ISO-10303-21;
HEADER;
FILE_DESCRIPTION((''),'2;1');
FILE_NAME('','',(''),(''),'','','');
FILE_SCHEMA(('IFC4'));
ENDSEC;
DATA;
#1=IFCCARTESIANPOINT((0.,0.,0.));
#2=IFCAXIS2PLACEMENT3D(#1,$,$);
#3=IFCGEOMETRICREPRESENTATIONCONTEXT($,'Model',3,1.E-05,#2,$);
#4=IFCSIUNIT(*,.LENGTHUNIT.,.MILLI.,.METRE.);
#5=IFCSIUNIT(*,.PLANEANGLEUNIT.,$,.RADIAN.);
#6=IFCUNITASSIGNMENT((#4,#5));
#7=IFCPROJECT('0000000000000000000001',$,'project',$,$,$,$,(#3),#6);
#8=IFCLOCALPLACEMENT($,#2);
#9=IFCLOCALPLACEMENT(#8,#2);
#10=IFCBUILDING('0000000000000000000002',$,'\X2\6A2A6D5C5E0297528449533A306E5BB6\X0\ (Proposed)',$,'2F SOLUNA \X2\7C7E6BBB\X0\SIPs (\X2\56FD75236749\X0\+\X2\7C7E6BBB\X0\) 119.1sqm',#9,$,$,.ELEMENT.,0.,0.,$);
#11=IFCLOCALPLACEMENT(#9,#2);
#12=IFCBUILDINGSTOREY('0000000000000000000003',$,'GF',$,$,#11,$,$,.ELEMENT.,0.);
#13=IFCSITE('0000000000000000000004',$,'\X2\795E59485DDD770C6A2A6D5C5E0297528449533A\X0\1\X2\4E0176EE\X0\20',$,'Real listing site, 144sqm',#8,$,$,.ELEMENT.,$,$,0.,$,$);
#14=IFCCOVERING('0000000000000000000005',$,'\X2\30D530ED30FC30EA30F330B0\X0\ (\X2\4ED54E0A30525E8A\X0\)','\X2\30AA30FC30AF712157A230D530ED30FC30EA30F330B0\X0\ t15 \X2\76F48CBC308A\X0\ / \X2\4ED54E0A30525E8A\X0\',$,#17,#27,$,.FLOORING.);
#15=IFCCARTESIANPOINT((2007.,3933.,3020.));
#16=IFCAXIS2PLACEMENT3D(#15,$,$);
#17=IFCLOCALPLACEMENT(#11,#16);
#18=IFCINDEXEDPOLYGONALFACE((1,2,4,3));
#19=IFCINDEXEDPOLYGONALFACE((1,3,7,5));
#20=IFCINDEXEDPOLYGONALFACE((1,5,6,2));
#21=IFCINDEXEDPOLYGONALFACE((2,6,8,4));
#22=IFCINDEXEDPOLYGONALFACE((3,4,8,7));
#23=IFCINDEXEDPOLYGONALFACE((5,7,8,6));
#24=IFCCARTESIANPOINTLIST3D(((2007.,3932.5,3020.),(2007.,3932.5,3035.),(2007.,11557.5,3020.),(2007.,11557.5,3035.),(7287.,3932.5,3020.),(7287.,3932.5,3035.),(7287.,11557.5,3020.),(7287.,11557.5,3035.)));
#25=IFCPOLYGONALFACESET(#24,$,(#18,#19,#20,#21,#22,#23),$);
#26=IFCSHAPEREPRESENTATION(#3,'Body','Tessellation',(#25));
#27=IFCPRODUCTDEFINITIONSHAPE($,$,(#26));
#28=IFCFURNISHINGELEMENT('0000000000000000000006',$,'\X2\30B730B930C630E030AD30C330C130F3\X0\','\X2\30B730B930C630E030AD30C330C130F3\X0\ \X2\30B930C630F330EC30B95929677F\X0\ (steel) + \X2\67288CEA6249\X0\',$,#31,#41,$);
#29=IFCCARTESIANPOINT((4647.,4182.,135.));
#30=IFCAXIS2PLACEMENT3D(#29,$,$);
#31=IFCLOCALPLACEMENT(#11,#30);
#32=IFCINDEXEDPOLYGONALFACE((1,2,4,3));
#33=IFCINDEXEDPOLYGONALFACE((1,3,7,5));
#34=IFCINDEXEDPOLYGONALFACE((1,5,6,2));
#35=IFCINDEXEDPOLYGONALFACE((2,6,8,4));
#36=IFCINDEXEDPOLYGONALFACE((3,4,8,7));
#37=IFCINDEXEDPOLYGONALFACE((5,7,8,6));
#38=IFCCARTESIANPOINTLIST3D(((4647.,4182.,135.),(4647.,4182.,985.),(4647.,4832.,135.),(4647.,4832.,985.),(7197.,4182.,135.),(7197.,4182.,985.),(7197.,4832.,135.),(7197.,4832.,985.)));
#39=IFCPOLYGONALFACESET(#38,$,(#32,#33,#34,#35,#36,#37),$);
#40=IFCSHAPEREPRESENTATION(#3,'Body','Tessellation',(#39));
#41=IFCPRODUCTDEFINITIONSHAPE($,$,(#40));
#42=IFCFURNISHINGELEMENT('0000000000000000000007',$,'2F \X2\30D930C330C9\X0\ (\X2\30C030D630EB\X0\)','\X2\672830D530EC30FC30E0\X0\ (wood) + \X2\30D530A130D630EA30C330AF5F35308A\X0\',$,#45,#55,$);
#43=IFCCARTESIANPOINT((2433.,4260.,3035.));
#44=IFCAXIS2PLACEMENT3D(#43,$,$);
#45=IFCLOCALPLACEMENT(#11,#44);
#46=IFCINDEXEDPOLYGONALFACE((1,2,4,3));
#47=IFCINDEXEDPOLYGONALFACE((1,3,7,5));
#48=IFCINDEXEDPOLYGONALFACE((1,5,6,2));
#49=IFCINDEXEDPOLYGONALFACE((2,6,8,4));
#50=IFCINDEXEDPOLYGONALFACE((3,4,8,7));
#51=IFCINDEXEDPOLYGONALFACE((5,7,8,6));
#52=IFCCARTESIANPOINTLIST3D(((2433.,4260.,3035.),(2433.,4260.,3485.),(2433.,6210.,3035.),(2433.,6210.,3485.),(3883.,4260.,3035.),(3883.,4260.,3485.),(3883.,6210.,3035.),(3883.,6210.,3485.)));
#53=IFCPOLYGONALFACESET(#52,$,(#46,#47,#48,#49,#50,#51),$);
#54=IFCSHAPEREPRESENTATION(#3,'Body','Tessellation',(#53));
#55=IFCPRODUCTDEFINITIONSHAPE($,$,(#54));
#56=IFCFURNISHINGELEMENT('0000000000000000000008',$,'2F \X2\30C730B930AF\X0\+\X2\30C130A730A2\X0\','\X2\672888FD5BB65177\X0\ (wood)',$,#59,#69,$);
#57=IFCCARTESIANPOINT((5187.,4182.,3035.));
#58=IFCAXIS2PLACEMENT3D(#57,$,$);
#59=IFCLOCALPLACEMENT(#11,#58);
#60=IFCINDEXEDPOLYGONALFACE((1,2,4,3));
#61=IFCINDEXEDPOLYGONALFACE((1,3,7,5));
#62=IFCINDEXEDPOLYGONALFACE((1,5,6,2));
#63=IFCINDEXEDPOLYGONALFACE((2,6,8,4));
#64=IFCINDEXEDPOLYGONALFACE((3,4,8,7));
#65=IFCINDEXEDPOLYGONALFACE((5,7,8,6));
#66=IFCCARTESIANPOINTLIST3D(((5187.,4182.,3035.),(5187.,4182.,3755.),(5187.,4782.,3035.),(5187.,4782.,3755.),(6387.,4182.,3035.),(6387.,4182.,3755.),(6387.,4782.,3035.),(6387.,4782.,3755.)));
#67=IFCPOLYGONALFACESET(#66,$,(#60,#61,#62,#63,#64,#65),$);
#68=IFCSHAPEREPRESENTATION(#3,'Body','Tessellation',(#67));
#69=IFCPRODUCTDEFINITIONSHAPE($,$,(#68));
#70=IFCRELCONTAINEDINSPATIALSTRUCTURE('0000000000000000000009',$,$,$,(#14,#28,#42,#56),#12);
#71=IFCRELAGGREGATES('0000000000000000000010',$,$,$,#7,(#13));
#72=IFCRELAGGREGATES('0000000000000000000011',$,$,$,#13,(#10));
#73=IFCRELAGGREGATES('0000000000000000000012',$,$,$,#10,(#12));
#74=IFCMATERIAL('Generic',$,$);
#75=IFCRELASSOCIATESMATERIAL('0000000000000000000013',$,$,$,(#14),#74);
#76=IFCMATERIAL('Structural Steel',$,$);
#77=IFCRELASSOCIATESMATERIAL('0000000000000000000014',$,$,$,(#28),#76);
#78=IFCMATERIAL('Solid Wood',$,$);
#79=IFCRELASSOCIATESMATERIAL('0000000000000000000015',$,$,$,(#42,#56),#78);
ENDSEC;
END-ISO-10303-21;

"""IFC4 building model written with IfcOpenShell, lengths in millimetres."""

from ifc_helpers import new_model, si_unit, frame, frame_2d, origin, place, context, project, spatial, rectangle, extrude, material, element, save


model = new_model("IFC4")

# Units and contexts
model_context = context("Model", 3, precision=1e-05, world=origin())
ifc_project = project(units=[si_unit("LENGTHUNIT", "METRE", prefix="MILLI"), si_unit("PLANEANGLEUNIT", "RADIAN")], contexts=[model_context])

# Site, building, storey
site_placement = place(None, origin())
site = spatial("IfcSite", under=ifc_project, at=site_placement, Name="神奈川県横浜市青葉区1丁目20", ObjectType="Real listing site, 144sqm", CompositionType="ELEMENT", RefElevation=0.0)
building_placement = place(site_placement, origin())
building = spatial("IfcBuilding", under=site, at=building_placement, Name="横浜市青葉区の家 (Proposed)", ObjectType="2F SOLUNA 籾殻SIPs (国産杉+籾殻) 119.1sqm", CompositionType="ELEMENT", ElevationOfRefHeight=0.0, ElevationOfTerrain=0.0)
storey_placement = place(building_placement, origin())
storey = spatial("IfcBuildingStorey", under=building, at=storey_placement, Name="GF", CompositionType="ELEMENT", Elevation=0.0)

# Shared definitions
ifc_material_1 = material(Name="Solid Wood")

# Shared definitions
ifc_material_2 = material(Name="Generic")

# Shared definitions
ifc_material_3 = material(Name="Structural Steel")

# Covering
covering_placement = place(storey_placement, frame((2007.0, 3933.0, 3020.0)))
element("IfcCovering", 1, at=covering_placement, inside=storey, material=ifc_material_2, Name="フローリング (仕上げ床)", Description="オーク無垢フローリング t15 直貼り / 仕上げ床", PredefinedType="FLOORING", context=model_context, shape_type="SweptSolid", body=[
    extrude(rectangle(XDim=5280.0, YDim=7625.0, at=frame_2d((2640.0, 3812.0))), frame((2007.0, 3933.0, 3020.0)), (0.0, 0.0, 1.0), 15.0),
])

# Furnishing elements
furnishing_1_placement = place(storey_placement, frame((4647.0, 4182.0, 135.0)))
element("IfcFurnishingElement", 2, at=furnishing_1_placement, inside=storey, material=ifc_material_3, Name="システムキッチン", Description="システムキッチン ステンレス天板 (steel) + 木質扉", context=model_context, shape_type="SweptSolid", body=[
    extrude(rectangle(XDim=2550.0, YDim=650.0, at=frame_2d((1275.0, 325.0))), frame((4647.0, 4182.0, 135.0)), (0.0, 0.0, 1.0), 850.0),
])
furnishing_2_placement = place(storey_placement, frame((2433.0, 4260.0, 3035.0)))
element("IfcFurnishingElement", 3, at=furnishing_2_placement, inside=storey, material=ifc_material_1, Name="2F ベッド (ダブル)", Description="木フレーム (wood) + ファブリック張り", context=model_context, shape_type="SweptSolid", body=[
    extrude(rectangle(XDim=1450.0, YDim=1950.0, at=frame_2d((725.0, 975.0))), frame((2433.0, 4260.0, 3035.0)), (0.0, 0.0, 1.0), 450.0),
])
furnishing_3_placement = place(storey_placement, frame((5187.0, 4182.0, 3035.0)))
element("IfcFurnishingElement", 4, at=furnishing_3_placement, inside=storey, material=ifc_material_1, Name="2F デスク+チェア", Description="木製家具 (wood)", context=model_context, shape_type="SweptSolid", body=[
    extrude(rectangle(XDim=1200.0, YDim=600.0, at=frame_2d((600.0, 300.0))), frame((5187.0, 4182.0, 3035.0)), (0.0, 0.0, 1.0), 720.0),
])

save(model, "model.ifc")
